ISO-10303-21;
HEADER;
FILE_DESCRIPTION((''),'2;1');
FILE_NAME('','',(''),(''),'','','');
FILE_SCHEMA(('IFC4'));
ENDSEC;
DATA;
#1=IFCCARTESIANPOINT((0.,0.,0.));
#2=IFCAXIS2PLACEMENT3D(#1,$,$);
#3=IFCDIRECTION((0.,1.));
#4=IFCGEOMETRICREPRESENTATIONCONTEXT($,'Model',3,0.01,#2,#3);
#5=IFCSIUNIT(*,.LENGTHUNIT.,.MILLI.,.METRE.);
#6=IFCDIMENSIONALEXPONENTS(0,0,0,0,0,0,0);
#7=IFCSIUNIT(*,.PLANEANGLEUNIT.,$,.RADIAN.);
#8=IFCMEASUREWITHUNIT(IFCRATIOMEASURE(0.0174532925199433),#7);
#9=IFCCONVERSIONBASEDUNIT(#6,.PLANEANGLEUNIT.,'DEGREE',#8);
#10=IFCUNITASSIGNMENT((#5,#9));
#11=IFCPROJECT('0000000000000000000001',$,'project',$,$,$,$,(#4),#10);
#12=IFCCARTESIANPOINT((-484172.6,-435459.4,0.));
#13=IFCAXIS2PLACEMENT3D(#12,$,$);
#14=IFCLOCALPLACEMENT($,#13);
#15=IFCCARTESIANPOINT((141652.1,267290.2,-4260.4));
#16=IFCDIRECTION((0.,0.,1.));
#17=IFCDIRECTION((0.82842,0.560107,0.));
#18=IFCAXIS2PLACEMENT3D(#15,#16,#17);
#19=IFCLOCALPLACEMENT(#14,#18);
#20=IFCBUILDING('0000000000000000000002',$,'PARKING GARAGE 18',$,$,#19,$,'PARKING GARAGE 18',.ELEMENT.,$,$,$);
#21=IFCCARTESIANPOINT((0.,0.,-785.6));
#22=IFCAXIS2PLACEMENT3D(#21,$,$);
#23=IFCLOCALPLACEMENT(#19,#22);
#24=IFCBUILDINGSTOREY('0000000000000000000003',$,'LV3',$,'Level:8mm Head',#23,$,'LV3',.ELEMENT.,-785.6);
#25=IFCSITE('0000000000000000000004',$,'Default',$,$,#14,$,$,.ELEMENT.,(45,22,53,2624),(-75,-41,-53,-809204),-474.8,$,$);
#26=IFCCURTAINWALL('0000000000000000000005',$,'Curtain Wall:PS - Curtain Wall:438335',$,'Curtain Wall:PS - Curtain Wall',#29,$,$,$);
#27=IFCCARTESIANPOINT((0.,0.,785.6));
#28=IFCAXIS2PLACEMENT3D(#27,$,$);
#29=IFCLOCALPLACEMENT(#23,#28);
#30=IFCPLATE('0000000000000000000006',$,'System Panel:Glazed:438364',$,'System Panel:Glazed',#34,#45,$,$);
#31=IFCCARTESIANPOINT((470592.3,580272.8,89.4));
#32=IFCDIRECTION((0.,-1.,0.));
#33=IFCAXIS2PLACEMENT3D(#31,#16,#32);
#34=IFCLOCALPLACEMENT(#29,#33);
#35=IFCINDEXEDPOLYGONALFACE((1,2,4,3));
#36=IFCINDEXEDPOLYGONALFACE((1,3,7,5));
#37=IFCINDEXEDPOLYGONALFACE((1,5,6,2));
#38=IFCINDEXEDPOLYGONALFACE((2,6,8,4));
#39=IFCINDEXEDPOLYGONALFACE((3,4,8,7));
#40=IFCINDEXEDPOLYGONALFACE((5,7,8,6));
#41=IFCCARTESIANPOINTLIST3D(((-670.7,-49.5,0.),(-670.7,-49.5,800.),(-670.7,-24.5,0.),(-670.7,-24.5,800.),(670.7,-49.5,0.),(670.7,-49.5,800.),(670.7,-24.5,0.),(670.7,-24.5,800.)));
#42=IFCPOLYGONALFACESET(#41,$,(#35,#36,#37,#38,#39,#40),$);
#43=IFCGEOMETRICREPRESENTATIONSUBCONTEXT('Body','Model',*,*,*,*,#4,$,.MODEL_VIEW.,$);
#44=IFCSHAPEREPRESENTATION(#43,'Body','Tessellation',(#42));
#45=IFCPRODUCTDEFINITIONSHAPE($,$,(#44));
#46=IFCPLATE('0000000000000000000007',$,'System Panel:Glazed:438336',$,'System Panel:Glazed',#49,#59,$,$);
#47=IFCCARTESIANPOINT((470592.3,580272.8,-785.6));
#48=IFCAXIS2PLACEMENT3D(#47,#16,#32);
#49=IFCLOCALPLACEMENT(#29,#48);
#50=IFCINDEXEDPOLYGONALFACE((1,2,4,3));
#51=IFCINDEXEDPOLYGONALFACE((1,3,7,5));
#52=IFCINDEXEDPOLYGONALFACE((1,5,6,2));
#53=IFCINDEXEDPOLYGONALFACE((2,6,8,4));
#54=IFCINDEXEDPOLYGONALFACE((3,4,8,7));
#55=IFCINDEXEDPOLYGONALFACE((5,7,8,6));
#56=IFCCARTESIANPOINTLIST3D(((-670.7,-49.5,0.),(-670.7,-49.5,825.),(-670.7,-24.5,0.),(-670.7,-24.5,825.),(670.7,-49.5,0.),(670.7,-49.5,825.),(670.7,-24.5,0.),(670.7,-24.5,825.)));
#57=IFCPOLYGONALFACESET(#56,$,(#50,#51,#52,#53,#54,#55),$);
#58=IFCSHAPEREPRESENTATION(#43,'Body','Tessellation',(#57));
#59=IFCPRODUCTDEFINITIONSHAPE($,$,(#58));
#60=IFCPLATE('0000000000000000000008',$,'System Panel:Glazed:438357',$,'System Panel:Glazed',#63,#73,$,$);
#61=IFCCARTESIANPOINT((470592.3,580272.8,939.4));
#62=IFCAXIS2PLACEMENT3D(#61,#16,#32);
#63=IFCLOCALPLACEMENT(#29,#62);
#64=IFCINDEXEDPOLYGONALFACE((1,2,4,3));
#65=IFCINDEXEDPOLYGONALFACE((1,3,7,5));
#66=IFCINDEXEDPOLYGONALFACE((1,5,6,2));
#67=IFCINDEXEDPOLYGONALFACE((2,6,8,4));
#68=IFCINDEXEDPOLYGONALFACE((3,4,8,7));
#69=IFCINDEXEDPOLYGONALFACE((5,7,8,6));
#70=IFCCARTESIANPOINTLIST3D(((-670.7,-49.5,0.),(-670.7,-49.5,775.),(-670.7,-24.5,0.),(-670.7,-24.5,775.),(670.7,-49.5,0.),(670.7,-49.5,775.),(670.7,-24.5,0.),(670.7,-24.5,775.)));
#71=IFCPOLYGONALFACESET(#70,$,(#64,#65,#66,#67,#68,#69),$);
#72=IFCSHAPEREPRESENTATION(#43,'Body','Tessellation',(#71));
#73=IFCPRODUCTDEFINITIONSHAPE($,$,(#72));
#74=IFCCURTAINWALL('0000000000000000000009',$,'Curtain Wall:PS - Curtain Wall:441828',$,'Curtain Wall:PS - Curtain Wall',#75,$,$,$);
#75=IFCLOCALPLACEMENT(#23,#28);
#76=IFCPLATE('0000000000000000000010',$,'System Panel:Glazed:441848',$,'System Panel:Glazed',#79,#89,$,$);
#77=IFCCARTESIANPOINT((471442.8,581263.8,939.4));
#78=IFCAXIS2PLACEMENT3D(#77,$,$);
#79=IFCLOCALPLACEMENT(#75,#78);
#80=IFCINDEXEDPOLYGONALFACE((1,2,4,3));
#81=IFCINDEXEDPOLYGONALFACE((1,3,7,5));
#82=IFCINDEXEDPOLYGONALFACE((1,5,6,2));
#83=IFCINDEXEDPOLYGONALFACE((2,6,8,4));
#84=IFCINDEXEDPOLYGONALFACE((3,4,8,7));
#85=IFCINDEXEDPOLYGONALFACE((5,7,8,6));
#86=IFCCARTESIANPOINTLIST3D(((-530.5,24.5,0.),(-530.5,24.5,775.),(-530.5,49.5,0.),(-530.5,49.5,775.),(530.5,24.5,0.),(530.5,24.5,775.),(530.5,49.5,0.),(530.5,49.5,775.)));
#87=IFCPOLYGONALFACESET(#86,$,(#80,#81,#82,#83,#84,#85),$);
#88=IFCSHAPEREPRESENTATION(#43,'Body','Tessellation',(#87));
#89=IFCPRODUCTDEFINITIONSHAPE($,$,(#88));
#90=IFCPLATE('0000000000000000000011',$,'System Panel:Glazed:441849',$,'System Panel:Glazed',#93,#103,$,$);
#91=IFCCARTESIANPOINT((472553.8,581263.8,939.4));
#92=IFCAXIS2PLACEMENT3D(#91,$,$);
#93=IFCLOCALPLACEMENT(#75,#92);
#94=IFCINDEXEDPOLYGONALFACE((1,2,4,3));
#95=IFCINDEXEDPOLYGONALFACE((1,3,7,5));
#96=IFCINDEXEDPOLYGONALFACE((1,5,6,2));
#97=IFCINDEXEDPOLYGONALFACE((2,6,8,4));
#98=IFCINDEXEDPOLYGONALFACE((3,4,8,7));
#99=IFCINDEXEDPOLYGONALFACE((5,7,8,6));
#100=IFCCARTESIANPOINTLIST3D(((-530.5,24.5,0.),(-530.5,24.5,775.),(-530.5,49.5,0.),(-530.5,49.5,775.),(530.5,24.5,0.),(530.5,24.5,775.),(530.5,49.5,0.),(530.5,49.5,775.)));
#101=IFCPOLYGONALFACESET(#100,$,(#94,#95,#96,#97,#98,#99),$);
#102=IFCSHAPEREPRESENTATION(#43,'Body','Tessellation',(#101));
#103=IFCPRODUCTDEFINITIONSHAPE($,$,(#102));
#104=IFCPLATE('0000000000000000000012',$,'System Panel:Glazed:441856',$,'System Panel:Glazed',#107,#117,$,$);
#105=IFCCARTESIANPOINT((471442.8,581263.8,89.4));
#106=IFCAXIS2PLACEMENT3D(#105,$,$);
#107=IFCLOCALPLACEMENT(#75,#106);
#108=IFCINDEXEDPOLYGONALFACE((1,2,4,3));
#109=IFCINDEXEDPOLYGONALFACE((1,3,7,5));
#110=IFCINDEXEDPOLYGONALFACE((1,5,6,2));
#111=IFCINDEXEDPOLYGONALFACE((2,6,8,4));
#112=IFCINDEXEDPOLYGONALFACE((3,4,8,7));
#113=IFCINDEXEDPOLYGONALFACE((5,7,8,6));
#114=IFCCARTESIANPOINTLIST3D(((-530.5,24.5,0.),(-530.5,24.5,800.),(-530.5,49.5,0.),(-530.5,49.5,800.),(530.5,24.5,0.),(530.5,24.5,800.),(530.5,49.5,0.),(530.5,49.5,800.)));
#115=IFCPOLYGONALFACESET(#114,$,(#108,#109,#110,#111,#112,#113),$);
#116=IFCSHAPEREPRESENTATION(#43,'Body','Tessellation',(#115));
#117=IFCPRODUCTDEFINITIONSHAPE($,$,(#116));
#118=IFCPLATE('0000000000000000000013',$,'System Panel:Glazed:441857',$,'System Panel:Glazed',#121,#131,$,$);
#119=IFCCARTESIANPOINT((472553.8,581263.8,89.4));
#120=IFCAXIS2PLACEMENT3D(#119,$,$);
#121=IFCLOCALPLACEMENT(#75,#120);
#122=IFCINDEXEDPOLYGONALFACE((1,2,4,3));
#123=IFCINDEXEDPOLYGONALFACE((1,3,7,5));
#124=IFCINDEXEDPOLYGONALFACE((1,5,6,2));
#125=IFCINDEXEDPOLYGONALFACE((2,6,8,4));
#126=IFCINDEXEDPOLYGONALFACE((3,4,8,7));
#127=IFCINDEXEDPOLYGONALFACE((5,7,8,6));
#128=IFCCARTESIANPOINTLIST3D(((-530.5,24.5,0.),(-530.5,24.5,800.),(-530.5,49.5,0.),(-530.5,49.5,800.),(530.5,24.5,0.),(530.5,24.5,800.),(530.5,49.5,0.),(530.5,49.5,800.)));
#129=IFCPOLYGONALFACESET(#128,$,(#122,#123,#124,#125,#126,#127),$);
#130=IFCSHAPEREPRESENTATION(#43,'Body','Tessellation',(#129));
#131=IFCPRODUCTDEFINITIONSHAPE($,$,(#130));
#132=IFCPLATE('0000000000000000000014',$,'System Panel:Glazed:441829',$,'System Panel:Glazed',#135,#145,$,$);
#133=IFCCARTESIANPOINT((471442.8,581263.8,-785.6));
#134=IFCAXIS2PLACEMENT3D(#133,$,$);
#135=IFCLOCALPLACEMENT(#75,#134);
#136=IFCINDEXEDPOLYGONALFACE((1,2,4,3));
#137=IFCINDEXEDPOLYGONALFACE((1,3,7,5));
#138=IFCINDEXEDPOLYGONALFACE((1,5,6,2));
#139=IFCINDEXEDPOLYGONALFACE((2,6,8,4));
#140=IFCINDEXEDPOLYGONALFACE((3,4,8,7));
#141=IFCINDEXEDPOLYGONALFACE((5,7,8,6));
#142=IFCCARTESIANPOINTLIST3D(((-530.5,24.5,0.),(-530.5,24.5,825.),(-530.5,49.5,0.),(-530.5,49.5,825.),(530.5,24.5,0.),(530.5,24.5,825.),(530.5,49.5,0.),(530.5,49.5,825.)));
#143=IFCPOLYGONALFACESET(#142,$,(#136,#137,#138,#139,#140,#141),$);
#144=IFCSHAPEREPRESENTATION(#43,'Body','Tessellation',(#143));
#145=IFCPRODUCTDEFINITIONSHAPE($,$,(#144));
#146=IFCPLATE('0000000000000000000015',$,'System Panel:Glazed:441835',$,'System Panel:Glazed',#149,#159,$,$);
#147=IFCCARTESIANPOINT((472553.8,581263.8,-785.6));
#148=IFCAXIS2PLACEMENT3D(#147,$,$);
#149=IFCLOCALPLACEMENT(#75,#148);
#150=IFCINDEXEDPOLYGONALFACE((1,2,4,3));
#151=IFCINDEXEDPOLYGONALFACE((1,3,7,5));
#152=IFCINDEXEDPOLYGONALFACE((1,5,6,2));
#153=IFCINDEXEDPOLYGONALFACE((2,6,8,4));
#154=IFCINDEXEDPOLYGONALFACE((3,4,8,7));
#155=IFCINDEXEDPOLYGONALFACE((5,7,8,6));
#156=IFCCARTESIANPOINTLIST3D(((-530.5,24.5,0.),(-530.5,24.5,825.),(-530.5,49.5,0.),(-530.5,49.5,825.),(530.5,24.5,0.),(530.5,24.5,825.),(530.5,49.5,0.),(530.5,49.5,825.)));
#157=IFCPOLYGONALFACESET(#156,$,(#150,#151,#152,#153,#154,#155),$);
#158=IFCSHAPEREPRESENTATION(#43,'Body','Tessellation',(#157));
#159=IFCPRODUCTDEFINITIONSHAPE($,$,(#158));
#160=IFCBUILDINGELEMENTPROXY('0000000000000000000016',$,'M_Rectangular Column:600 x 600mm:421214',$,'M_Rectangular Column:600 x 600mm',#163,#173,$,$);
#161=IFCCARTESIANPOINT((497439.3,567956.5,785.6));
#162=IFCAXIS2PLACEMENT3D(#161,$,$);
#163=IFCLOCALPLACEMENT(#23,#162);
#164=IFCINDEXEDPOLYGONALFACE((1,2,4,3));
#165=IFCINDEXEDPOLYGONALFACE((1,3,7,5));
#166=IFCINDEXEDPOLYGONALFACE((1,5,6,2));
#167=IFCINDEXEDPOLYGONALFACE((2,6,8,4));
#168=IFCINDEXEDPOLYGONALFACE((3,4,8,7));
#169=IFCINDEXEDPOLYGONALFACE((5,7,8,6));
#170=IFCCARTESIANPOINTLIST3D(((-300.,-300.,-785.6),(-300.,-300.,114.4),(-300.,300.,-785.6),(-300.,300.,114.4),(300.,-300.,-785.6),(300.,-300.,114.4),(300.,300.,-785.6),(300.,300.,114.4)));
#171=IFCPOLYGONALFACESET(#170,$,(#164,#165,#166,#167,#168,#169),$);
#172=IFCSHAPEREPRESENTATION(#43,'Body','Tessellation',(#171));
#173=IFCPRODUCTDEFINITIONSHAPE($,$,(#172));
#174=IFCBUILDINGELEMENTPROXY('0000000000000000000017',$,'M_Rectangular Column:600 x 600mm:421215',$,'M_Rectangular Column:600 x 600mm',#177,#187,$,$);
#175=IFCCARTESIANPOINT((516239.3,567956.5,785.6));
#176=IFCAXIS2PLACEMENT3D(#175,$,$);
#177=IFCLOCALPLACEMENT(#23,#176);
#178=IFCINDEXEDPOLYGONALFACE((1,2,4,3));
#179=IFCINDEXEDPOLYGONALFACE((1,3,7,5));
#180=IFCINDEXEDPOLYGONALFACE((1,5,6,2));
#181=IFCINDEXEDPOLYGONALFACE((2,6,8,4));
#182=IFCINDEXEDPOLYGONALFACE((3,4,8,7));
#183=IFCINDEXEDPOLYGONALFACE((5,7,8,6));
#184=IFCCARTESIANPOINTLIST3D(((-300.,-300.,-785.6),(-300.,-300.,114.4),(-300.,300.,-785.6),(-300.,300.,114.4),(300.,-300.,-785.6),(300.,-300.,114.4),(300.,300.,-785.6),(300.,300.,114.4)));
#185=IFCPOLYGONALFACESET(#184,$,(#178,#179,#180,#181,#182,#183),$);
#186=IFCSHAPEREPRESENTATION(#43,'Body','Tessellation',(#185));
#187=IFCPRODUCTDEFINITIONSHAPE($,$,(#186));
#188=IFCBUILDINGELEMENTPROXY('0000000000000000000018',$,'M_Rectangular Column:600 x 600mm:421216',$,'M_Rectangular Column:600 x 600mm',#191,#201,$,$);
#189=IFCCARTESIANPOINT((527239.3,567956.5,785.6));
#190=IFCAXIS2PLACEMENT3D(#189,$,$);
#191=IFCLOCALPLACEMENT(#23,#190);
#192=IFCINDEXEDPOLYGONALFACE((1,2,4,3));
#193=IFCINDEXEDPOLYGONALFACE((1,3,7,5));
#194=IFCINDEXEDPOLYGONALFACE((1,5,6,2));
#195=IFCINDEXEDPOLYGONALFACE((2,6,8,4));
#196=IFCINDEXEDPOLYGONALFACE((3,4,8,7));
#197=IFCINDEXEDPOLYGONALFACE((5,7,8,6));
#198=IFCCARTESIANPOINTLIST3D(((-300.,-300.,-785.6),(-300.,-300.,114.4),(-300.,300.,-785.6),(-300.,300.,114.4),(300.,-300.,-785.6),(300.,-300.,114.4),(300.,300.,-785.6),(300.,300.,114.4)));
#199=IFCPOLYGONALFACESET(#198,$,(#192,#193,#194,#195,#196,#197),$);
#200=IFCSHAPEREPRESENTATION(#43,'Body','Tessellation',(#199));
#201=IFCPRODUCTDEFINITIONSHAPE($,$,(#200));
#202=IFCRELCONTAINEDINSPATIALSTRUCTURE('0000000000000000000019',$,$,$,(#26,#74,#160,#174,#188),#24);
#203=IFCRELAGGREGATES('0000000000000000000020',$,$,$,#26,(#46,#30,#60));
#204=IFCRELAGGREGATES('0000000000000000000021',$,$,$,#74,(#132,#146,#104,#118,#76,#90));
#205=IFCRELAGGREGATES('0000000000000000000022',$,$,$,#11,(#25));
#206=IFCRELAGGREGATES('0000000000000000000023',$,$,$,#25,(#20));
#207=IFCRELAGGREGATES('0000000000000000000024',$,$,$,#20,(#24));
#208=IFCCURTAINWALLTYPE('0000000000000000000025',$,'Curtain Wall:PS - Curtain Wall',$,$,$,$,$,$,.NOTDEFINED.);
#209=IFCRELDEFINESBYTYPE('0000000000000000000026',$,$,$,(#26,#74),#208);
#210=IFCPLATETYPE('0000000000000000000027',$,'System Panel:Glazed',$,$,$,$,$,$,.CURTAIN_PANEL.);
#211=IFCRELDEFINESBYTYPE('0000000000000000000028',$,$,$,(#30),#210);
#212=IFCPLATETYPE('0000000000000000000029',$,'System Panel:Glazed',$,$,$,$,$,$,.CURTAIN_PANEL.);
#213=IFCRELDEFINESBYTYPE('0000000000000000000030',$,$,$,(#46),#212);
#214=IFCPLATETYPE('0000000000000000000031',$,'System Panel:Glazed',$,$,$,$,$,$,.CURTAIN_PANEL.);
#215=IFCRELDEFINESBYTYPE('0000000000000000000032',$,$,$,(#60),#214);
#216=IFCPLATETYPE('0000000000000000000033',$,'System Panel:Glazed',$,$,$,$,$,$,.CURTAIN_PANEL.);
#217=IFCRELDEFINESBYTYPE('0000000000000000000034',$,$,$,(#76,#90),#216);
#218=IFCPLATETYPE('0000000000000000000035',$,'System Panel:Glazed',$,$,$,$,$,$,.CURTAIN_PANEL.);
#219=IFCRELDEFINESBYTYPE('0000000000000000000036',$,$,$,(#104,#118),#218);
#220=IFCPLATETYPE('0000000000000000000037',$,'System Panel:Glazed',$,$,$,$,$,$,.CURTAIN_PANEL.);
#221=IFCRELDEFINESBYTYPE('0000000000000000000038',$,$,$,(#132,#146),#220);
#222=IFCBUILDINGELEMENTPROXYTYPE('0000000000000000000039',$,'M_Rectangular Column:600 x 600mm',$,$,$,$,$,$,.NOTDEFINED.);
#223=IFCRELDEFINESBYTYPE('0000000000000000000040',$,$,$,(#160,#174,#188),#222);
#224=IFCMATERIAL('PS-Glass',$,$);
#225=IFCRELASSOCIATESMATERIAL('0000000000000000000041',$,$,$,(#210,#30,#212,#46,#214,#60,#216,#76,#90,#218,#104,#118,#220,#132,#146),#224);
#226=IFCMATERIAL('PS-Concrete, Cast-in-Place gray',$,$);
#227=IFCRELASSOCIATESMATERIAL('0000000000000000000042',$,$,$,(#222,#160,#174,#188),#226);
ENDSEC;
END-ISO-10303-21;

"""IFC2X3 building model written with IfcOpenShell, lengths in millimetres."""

from ifc_helpers import new_model, entity, si_unit, converted_unit, direction, frame, frame_2d, origin, origin_2d_with_axis, place, context, subcontext, project, spatial, rectangle, extrude, source, transform, mapped, material, type_object, type_shapes, element, aggregate, save


model = new_model("IFC2X3")

# Units and contexts
model_context = context("Model", 3, precision=0.01, world=origin(), true_north=direction((0.0, 1.0)))
body_context = subcontext(model_context, "Body", "Model", "MODEL_VIEW")
ifc_project = project(units=[si_unit("LENGTHUNIT", "METRE", prefix="MILLI"), converted_unit("PLANEANGLEUNIT", "DEGREE", entity("IfcRatioMeasure", 0.0174532925199433), si_unit("PLANEANGLEUNIT", "RADIAN"), dimensions=[0, 0, 0, 0, 0, 0, 0])], contexts=[model_context])

# Site, building, storey
site_placement = place(None, frame((-484172.6, -435459.4, 0.0)))
site = spatial("IfcSite", under=ifc_project, at=site_placement, Name="Default", CompositionType="ELEMENT", RefLatitude=(45, 22, 53, 2624), RefLongitude=(-75, -41, -53, -809204), RefElevation=-474.8)
building_placement = place(site_placement, frame((141652.1, 267290.2, -4260.4), z_axis=(0.0, 0.0, 1.0), x_axis=(0.82842, 0.560107, 0.0)))
building = spatial("IfcBuilding", under=site, at=building_placement, Name="PARKING GARAGE 18", LongName="PARKING GARAGE 18", CompositionType="ELEMENT")
storey_placement = place(building_placement, frame((0.0, 0.0, -785.6)))
storey = spatial("IfcBuildingStorey", under=building, at=storey_placement, Name="LV3", ObjectType="Level:8mm Head", LongName="LV3", CompositionType="ELEMENT", Elevation=-785.6)

# Curtain walls, plates
curtain_wall_type = type_object("IfcCurtainWallType", Name="Curtain Wall:PS - Curtain Wall", PredefinedType="NOTDEFINED")
curtain_wall_1_placement = place(storey_placement, frame((0.0, 0.0, 785.6)))
curtain_wall_1 = element("IfcCurtainWall", 1, at=curtain_wall_1_placement, inside=storey, type_object=curtain_wall_type, Name="Curtain Wall:PS - Curtain Wall:438335", ObjectType="Curtain Wall:PS - Curtain Wall")
ifc_material_1 = material(Name="PS-Glass")
plate_type_1 = type_object("IfcPlateType", Name="System Panel:Glazed", PredefinedType="CURTAIN_PANEL", material=ifc_material_1)
shared_shape_1 = source(origin(), body_context, "Body", "SweptSolid", [
    extrude(rectangle(XDim=25.0, YDim=1341.5, at=frame_2d((0.0, 0.0), x_axis=(1.0, 0.0))), frame((0.0, -37.0, 0.0), z_axis=(0.0, 0.0, 1.0), x_axis=(0.0, 1.0, 0.0)), (0.0, 0.0, 1.0), 800.0),
])
type_shapes(plate_type_1, [shared_shape_1])
plate_1_placement = place(curtain_wall_1_placement, frame((470592.3, 580272.8, 89.4), z_axis=(0.0, 0.0, 1.0), x_axis=(0.0, -1.0, 0.0)))
plate_1 = element("IfcPlate", 2, at=plate_1_placement, type_object=plate_type_1, material=ifc_material_1, Name="System Panel:Glazed:438364", ObjectType="System Panel:Glazed", context=body_context, shape_type="MappedRepresentation", body=[
    mapped(shared_shape_1, transform((0.0, 0.0, 0.0), scale=1.0)),
])
plate_type_2 = type_object("IfcPlateType", Name="System Panel:Glazed", PredefinedType="CURTAIN_PANEL", material=ifc_material_1)
shared_shape_2 = source(origin(), body_context, "Body", "SweptSolid", [
    extrude(rectangle(XDim=25.0, YDim=1341.5, at=frame_2d((0.0, 0.0), x_axis=(1.0, 0.0))), frame((0.0, -37.0, 0.0), z_axis=(0.0, 0.0, 1.0), x_axis=(0.0, 1.0, 0.0)), (0.0, 0.0, 1.0), 825.0),
])
type_shapes(plate_type_2, [shared_shape_2])
plate_2_placement = place(curtain_wall_1_placement, frame((470592.3, 580272.8, -785.6), z_axis=(0.0, 0.0, 1.0), x_axis=(0.0, -1.0, 0.0)))
plate_2 = element("IfcPlate", 3, at=plate_2_placement, type_object=plate_type_2, material=ifc_material_1, Name="System Panel:Glazed:438336", ObjectType="System Panel:Glazed", context=body_context, shape_type="MappedRepresentation", body=[
    mapped(shared_shape_2, transform((0.0, 0.0, 0.0), scale=1.0)),
])
plate_type_3 = type_object("IfcPlateType", Name="System Panel:Glazed", PredefinedType="CURTAIN_PANEL", material=ifc_material_1)
shared_shape_3 = source(origin(), body_context, "Body", "SweptSolid", [
    extrude(rectangle(XDim=25.0, YDim=1341.5, at=frame_2d((0.0, 0.0), x_axis=(1.0, 0.0))), frame((0.0, -37.0, 0.0), z_axis=(0.0, 0.0, 1.0), x_axis=(0.0, 1.0, 0.0)), (0.0, 0.0, 1.0), 775.0),
])
type_shapes(plate_type_3, [shared_shape_3])
plate_3_placement = place(curtain_wall_1_placement, frame((470592.3, 580272.8, 939.4), z_axis=(0.0, 0.0, 1.0), x_axis=(0.0, -1.0, 0.0)))
plate_3 = element("IfcPlate", 4, at=plate_3_placement, type_object=plate_type_3, material=ifc_material_1, Name="System Panel:Glazed:438357", ObjectType="System Panel:Glazed", context=body_context, shape_type="MappedRepresentation", body=[
    mapped(shared_shape_3, transform((0.0, 0.0, 0.0), scale=1.0)),
])
aggregate(curtain_wall_1, [plate_2, plate_1, plate_3])
curtain_wall_2_placement = place(storey_placement, frame((0.0, 0.0, 785.6)))
curtain_wall_2 = element("IfcCurtainWall", 5, at=curtain_wall_2_placement, inside=storey, type_object=curtain_wall_type, Name="Curtain Wall:PS - Curtain Wall:441828", ObjectType="Curtain Wall:PS - Curtain Wall")
plate_type_4 = type_object("IfcPlateType", Name="System Panel:Glazed", PredefinedType="CURTAIN_PANEL", material=ifc_material_1)
shared_shape_4 = source(origin(), body_context, "Body", "SweptSolid", [
    extrude(rectangle(XDim=25.0, YDim=1061.0, at=origin_2d_with_axis()), frame((0.0, 37.0, 0.0), z_axis=(0.0, 0.0, 1.0), x_axis=(0.0, 1.0, 0.0)), (0.0, 0.0, 1.0), 775.0),
])
type_shapes(plate_type_4, [shared_shape_4])
plate_4_placement = place(curtain_wall_2_placement, frame((471442.8, 581263.8, 939.4)))
plate_4 = element("IfcPlate", 6, at=plate_4_placement, type_object=plate_type_4, material=ifc_material_1, Name="System Panel:Glazed:441848", ObjectType="System Panel:Glazed", context=body_context, shape_type="MappedRepresentation", body=[
    mapped(shared_shape_4, transform((0.0, 0.0, 0.0), scale=1.0)),
])
plate_5_placement = place(curtain_wall_2_placement, frame((472553.8, 581263.8, 939.4)))
plate_5 = element("IfcPlate", 7, at=plate_5_placement, type_object=plate_type_4, material=ifc_material_1, Name="System Panel:Glazed:441849", ObjectType="System Panel:Glazed", context=body_context, shape_type="MappedRepresentation", body=[
    mapped(shared_shape_4, transform((0.0, 0.0, 0.0), scale=1.0)),
])
plate_type_5 = type_object("IfcPlateType", Name="System Panel:Glazed", PredefinedType="CURTAIN_PANEL", material=ifc_material_1)
shared_shape_5 = source(origin(), body_context, "Body", "SweptSolid", [
    extrude(rectangle(XDim=25.0, YDim=1061.0, at=origin_2d_with_axis()), frame((0.0, 37.0, 0.0), z_axis=(0.0, 0.0, 1.0), x_axis=(0.0, 1.0, 0.0)), (0.0, 0.0, 1.0), 800.0),
])
type_shapes(plate_type_5, [shared_shape_5])
plate_6_placement = place(curtain_wall_2_placement, frame((471442.8, 581263.8, 89.4)))
plate_6 = element("IfcPlate", 8, at=plate_6_placement, type_object=plate_type_5, material=ifc_material_1, Name="System Panel:Glazed:441856", ObjectType="System Panel:Glazed", context=body_context, shape_type="MappedRepresentation", body=[
    mapped(shared_shape_5, transform((0.0, 0.0, 0.0), scale=1.0)),
])
plate_7_placement = place(curtain_wall_2_placement, frame((472553.8, 581263.8, 89.4)))
plate_7 = element("IfcPlate", 9, at=plate_7_placement, type_object=plate_type_5, material=ifc_material_1, Name="System Panel:Glazed:441857", ObjectType="System Panel:Glazed", context=body_context, shape_type="MappedRepresentation", body=[
    mapped(shared_shape_5, transform((0.0, 0.0, 0.0), scale=1.0)),
])
plate_type_6 = type_object("IfcPlateType", Name="System Panel:Glazed", PredefinedType="CURTAIN_PANEL", material=ifc_material_1)
shared_shape_6 = source(origin(), body_context, "Body", "SweptSolid", [
    extrude(rectangle(XDim=25.0, YDim=1061.0, at=origin_2d_with_axis()), frame((0.0, 37.0, 0.0), z_axis=(0.0, 0.0, 1.0), x_axis=(0.0, 1.0, 0.0)), (0.0, 0.0, 1.0), 825.0),
])
type_shapes(plate_type_6, [shared_shape_6])
plate_8_placement = place(curtain_wall_2_placement, frame((471442.8, 581263.8, -785.6)))
plate_8 = element("IfcPlate", 10, at=plate_8_placement, type_object=plate_type_6, material=ifc_material_1, Name="System Panel:Glazed:441829", ObjectType="System Panel:Glazed", context=body_context, shape_type="MappedRepresentation", body=[
    mapped(shared_shape_6, transform((0.0, 0.0, 0.0), scale=1.0)),
])
plate_9_placement = place(curtain_wall_2_placement, frame((472553.8, 581263.8, -785.6)))
plate_9 = element("IfcPlate", 11, at=plate_9_placement, type_object=plate_type_6, material=ifc_material_1, Name="System Panel:Glazed:441835", ObjectType="System Panel:Glazed", context=body_context, shape_type="MappedRepresentation", body=[
    mapped(shared_shape_6, transform((0.0, 0.0, 0.0), scale=1.0)),
])
aggregate(curtain_wall_2, [plate_8, plate_9, plate_6, plate_7, plate_4, plate_5])

# Shared definitions
ifc_material_2 = material(Name="PS-Concrete, Cast-in-Place gray")

# Building element proxies
building_element_proxy_type_1 = type_object("IfcBuildingElementProxyType", Name="M_Rectangular Column:600 x 600mm", PredefinedType="NOTDEFINED", material=ifc_material_2)
shared_shape_7 = source(origin(), body_context, "Body", "SweptSolid", [
    extrude(rectangle(XDim=600.0, YDim=600.0, at=origin_2d_with_axis()), frame((0.0, 0.0, -785.6), z_axis=(0.0, 0.0, 1.0), x_axis=(-1.0, 0.0, 0.0)), (0.0, 0.0, 1.0), 900.0),
])
type_shapes(building_element_proxy_type_1, [shared_shape_7])
for number, where, name in (
    (12, (497439.3, 567956.5, 785.6), "M_Rectangular Column:600 x 600mm:421214"),
    (13, (516239.3, 567956.5, 785.6), "M_Rectangular Column:600 x 600mm:421215"),
    (14, (527239.3, 567956.5, 785.6), "M_Rectangular Column:600 x 600mm:421216"),
):
    element("IfcBuildingElementProxy", number, at=place(storey_placement, frame(where)), inside=storey, type_object=building_element_proxy_type_1, material=ifc_material_2, Name=name, ObjectType="M_Rectangular Column:600 x 600mm", context=body_context, shape_type="MappedRepresentation", body=[
        mapped(shared_shape_7, transform((0.0, 0.0, 0.0), scale=1.0)),
    ])

save(model, "model.ifc")
